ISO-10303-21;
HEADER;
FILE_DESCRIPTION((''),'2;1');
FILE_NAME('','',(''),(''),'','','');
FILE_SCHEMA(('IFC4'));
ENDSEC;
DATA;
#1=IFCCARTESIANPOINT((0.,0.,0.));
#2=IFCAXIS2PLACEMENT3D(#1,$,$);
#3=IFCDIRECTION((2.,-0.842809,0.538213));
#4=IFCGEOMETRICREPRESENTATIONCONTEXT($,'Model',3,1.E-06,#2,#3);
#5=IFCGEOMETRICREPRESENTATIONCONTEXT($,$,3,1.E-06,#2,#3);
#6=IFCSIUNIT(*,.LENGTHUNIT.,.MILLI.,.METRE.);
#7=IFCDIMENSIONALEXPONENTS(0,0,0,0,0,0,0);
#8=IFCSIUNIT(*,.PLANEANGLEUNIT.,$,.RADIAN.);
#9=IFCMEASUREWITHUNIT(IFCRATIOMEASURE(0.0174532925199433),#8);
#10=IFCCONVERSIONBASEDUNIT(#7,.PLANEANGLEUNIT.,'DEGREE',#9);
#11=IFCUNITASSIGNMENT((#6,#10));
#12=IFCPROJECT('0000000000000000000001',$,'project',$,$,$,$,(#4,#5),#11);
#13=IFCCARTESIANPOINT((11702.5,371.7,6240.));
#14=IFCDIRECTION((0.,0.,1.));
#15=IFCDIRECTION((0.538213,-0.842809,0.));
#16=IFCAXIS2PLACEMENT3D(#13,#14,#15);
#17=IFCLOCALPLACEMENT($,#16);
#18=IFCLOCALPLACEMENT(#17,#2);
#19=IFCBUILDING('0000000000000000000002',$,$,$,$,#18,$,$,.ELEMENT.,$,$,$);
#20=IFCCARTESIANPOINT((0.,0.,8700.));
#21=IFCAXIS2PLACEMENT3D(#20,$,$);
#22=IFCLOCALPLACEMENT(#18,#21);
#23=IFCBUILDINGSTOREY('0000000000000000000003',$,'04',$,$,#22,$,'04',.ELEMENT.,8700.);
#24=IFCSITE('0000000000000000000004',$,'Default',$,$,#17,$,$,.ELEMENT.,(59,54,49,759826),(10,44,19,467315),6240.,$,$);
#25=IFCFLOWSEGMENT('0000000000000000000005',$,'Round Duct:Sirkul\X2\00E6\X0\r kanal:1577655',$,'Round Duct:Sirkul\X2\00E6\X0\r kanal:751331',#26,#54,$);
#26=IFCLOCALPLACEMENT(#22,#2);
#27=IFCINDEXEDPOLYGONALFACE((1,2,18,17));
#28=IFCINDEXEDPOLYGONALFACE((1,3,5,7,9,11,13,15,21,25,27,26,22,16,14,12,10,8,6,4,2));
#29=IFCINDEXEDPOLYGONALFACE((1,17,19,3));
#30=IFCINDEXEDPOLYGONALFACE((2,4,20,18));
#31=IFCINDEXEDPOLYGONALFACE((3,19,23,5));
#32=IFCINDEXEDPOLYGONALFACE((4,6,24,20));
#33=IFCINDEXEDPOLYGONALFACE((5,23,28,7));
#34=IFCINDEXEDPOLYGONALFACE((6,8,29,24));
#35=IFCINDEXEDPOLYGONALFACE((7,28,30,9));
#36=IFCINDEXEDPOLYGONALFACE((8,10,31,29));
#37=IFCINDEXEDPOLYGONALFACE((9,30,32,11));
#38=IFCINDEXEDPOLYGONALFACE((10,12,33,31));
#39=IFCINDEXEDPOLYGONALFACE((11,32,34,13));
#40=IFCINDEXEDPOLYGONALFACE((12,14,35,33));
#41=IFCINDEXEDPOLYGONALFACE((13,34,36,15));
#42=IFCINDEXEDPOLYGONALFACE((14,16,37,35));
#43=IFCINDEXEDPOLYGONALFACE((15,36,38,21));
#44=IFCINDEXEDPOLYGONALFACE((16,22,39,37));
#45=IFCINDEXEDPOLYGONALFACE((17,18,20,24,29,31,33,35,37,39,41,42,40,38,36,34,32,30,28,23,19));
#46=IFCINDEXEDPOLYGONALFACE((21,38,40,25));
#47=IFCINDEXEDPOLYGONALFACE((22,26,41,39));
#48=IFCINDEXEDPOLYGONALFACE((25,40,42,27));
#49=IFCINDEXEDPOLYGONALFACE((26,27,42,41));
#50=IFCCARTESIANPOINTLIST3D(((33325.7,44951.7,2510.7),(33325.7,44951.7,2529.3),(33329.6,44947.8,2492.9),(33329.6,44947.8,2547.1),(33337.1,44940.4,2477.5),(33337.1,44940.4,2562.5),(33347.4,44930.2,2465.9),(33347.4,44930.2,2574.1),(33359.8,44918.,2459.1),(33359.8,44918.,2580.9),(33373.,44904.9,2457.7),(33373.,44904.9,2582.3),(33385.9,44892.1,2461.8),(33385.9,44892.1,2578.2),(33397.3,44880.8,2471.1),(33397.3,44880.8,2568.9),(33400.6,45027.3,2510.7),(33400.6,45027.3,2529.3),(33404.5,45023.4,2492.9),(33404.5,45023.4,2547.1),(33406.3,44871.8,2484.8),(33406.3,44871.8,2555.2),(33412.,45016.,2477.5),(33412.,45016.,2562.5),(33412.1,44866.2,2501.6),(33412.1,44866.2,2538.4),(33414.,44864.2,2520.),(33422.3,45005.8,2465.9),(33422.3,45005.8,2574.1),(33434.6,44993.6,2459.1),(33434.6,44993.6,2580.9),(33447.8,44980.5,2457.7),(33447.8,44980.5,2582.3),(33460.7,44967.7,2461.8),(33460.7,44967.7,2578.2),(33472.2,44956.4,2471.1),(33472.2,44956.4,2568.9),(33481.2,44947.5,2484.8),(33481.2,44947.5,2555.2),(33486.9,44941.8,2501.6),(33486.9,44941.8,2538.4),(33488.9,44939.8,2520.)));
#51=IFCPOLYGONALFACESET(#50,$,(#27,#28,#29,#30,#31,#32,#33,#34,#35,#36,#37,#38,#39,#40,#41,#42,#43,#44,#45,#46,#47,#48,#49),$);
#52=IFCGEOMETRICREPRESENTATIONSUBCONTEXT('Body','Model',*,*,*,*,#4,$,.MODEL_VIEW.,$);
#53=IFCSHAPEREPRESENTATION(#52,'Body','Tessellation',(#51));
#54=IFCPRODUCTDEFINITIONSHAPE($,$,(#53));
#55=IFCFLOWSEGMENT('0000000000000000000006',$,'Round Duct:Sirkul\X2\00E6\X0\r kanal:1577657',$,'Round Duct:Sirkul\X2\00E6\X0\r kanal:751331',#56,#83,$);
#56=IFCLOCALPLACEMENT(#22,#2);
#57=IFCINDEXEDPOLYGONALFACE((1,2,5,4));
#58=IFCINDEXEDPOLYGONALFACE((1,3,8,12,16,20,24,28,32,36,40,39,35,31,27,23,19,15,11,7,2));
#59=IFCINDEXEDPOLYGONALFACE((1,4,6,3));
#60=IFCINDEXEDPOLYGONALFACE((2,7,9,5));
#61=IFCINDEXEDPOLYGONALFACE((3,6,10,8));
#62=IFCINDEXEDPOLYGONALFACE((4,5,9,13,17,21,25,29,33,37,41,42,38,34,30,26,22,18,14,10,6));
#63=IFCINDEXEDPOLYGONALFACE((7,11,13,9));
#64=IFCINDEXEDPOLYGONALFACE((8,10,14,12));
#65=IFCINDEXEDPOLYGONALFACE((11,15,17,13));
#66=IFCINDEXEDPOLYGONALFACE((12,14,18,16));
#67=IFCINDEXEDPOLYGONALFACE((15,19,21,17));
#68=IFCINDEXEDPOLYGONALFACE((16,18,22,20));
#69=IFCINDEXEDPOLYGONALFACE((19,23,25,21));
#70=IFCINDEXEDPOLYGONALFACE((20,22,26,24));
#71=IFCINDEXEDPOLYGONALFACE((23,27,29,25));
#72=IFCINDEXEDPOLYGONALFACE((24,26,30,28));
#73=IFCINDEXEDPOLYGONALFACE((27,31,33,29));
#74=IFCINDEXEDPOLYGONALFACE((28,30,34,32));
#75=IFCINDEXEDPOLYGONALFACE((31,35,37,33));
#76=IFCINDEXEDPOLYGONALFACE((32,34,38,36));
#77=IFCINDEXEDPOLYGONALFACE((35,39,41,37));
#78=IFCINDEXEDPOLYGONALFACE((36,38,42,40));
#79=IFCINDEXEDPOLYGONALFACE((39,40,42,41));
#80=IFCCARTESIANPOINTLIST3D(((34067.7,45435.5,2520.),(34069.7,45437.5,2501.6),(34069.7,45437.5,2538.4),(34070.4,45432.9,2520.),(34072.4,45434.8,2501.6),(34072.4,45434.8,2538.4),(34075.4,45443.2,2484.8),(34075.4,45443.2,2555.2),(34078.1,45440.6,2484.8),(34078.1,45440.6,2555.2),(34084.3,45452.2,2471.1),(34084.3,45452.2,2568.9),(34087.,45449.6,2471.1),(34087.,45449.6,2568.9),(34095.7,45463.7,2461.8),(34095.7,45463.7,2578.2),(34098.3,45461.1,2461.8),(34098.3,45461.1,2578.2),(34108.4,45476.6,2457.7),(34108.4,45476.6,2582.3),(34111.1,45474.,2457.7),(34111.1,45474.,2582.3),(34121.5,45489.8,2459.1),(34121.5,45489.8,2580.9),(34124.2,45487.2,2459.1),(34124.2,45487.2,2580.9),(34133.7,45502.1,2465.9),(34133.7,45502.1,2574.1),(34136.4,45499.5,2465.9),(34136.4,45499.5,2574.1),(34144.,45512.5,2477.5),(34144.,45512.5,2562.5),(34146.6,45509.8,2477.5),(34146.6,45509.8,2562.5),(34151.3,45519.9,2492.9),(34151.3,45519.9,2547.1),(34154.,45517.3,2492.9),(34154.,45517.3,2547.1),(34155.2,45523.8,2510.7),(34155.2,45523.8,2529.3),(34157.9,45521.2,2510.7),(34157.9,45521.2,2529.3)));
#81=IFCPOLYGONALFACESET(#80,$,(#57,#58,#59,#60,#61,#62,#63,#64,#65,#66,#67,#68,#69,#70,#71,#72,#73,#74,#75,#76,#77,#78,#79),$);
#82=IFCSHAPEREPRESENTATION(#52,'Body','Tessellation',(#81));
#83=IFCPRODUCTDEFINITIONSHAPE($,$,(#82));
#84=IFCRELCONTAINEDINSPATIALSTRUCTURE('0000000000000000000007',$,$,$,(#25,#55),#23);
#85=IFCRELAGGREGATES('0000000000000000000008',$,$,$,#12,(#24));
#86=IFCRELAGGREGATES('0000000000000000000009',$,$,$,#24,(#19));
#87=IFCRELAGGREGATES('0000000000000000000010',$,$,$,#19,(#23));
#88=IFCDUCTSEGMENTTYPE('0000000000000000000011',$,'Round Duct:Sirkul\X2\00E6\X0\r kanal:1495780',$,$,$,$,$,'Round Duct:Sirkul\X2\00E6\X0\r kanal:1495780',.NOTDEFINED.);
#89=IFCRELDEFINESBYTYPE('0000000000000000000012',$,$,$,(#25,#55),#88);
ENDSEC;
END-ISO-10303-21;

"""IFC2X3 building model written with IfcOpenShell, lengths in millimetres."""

from ifc_helpers import new_model, entity, si_unit, converted_unit, direction, frame, origin, origin_2d_with_axis, place, context, subcontext, project, spatial, circle, extrude, type_object, element, save


model = new_model("IFC2X3")

# Units and contexts
model_context = context("Model", 3, precision=1e-06, world=origin(), true_north=direction((2.0, -0.842809, 0.538213)))
context_of_model = context(None, 3, precision=1e-06, world=origin(), true_north=direction((2.0, -0.842809, 0.538213)))
body_context = subcontext(model_context, "Body", "Model", "MODEL_VIEW")
ifc_project = project(units=[si_unit("LENGTHUNIT", "METRE", prefix="MILLI"), converted_unit("PLANEANGLEUNIT", "DEGREE", entity("IfcRatioMeasure", 0.0174532925199433), si_unit("PLANEANGLEUNIT", "RADIAN"), dimensions=[0, 0, 0, 0, 0, 0, 0])], contexts=[model_context, context_of_model])

# Site, building, storey
site_placement = place(None, frame((11702.5, 371.7, 6240.0), z_axis=(0.0, 0.0, 1.0), x_axis=(0.538213, -0.842809, 0.0)))
site = spatial("IfcSite", under=ifc_project, at=site_placement, Name="Default", CompositionType="ELEMENT", RefLatitude=(59, 54, 49, 759826), RefLongitude=(10, 44, 19, 467315), RefElevation=6240.0)
building_placement = place(site_placement, origin())
building = spatial("IfcBuilding", under=site, at=building_placement, CompositionType="ELEMENT")
storey_placement = place(building_placement, frame((0.0, 0.0, 8700.0)))
storey = spatial("IfcBuildingStorey", under=building, at=storey_placement, Name="04", LongName="04", CompositionType="ELEMENT", Elevation=8700.0)

# Flow segments
duct_segment_type = type_object("IfcDuctSegmentType", Name="Round Duct:Sirkulær kanal:1495780", ElementType="Round Duct:Sirkulær kanal:1495780", PredefinedType="NOTDEFINED")
flow_segment_1_placement = place(storey_placement, origin())
element("IfcFlowSegment", 1, at=flow_segment_1_placement, inside=storey, type_object=duct_segment_type, Name="Round Duct:Sirkulær kanal:1577655", ObjectType="Round Duct:Sirkulær kanal:751331", context=body_context, shape_type="SweptSolid", body=[
    extrude(circle(Radius=62.5, at=origin_2d_with_axis()), frame((33369.6, 44908.2, 2520.0), z_axis=(0.703643, 0.710554, 0.0), x_axis=(0.710554, -0.703643, 0.0)), (0.0, 0.0, 1.0), 106.4),
])
flow_segment_2_placement = place(storey_placement, origin())
element("IfcFlowSegment", 2, at=flow_segment_2_placement, inside=storey, type_object=duct_segment_type, Name="Round Duct:Sirkulær kanal:1577657", ObjectType="Round Duct:Sirkulær kanal:751331", context=body_context, shape_type="SweptSolid", body=[
    extrude(circle(Radius=62.5, at=origin_2d_with_axis()), frame((34111.7, 45479.9, 2520.0), z_axis=(0.710554, -0.703643, 0.0), x_axis=(-0.703643, -0.710554, 0.0)), (0.0, 0.0, 1.0), 3.7),
])

save(model, "model.ifc")
